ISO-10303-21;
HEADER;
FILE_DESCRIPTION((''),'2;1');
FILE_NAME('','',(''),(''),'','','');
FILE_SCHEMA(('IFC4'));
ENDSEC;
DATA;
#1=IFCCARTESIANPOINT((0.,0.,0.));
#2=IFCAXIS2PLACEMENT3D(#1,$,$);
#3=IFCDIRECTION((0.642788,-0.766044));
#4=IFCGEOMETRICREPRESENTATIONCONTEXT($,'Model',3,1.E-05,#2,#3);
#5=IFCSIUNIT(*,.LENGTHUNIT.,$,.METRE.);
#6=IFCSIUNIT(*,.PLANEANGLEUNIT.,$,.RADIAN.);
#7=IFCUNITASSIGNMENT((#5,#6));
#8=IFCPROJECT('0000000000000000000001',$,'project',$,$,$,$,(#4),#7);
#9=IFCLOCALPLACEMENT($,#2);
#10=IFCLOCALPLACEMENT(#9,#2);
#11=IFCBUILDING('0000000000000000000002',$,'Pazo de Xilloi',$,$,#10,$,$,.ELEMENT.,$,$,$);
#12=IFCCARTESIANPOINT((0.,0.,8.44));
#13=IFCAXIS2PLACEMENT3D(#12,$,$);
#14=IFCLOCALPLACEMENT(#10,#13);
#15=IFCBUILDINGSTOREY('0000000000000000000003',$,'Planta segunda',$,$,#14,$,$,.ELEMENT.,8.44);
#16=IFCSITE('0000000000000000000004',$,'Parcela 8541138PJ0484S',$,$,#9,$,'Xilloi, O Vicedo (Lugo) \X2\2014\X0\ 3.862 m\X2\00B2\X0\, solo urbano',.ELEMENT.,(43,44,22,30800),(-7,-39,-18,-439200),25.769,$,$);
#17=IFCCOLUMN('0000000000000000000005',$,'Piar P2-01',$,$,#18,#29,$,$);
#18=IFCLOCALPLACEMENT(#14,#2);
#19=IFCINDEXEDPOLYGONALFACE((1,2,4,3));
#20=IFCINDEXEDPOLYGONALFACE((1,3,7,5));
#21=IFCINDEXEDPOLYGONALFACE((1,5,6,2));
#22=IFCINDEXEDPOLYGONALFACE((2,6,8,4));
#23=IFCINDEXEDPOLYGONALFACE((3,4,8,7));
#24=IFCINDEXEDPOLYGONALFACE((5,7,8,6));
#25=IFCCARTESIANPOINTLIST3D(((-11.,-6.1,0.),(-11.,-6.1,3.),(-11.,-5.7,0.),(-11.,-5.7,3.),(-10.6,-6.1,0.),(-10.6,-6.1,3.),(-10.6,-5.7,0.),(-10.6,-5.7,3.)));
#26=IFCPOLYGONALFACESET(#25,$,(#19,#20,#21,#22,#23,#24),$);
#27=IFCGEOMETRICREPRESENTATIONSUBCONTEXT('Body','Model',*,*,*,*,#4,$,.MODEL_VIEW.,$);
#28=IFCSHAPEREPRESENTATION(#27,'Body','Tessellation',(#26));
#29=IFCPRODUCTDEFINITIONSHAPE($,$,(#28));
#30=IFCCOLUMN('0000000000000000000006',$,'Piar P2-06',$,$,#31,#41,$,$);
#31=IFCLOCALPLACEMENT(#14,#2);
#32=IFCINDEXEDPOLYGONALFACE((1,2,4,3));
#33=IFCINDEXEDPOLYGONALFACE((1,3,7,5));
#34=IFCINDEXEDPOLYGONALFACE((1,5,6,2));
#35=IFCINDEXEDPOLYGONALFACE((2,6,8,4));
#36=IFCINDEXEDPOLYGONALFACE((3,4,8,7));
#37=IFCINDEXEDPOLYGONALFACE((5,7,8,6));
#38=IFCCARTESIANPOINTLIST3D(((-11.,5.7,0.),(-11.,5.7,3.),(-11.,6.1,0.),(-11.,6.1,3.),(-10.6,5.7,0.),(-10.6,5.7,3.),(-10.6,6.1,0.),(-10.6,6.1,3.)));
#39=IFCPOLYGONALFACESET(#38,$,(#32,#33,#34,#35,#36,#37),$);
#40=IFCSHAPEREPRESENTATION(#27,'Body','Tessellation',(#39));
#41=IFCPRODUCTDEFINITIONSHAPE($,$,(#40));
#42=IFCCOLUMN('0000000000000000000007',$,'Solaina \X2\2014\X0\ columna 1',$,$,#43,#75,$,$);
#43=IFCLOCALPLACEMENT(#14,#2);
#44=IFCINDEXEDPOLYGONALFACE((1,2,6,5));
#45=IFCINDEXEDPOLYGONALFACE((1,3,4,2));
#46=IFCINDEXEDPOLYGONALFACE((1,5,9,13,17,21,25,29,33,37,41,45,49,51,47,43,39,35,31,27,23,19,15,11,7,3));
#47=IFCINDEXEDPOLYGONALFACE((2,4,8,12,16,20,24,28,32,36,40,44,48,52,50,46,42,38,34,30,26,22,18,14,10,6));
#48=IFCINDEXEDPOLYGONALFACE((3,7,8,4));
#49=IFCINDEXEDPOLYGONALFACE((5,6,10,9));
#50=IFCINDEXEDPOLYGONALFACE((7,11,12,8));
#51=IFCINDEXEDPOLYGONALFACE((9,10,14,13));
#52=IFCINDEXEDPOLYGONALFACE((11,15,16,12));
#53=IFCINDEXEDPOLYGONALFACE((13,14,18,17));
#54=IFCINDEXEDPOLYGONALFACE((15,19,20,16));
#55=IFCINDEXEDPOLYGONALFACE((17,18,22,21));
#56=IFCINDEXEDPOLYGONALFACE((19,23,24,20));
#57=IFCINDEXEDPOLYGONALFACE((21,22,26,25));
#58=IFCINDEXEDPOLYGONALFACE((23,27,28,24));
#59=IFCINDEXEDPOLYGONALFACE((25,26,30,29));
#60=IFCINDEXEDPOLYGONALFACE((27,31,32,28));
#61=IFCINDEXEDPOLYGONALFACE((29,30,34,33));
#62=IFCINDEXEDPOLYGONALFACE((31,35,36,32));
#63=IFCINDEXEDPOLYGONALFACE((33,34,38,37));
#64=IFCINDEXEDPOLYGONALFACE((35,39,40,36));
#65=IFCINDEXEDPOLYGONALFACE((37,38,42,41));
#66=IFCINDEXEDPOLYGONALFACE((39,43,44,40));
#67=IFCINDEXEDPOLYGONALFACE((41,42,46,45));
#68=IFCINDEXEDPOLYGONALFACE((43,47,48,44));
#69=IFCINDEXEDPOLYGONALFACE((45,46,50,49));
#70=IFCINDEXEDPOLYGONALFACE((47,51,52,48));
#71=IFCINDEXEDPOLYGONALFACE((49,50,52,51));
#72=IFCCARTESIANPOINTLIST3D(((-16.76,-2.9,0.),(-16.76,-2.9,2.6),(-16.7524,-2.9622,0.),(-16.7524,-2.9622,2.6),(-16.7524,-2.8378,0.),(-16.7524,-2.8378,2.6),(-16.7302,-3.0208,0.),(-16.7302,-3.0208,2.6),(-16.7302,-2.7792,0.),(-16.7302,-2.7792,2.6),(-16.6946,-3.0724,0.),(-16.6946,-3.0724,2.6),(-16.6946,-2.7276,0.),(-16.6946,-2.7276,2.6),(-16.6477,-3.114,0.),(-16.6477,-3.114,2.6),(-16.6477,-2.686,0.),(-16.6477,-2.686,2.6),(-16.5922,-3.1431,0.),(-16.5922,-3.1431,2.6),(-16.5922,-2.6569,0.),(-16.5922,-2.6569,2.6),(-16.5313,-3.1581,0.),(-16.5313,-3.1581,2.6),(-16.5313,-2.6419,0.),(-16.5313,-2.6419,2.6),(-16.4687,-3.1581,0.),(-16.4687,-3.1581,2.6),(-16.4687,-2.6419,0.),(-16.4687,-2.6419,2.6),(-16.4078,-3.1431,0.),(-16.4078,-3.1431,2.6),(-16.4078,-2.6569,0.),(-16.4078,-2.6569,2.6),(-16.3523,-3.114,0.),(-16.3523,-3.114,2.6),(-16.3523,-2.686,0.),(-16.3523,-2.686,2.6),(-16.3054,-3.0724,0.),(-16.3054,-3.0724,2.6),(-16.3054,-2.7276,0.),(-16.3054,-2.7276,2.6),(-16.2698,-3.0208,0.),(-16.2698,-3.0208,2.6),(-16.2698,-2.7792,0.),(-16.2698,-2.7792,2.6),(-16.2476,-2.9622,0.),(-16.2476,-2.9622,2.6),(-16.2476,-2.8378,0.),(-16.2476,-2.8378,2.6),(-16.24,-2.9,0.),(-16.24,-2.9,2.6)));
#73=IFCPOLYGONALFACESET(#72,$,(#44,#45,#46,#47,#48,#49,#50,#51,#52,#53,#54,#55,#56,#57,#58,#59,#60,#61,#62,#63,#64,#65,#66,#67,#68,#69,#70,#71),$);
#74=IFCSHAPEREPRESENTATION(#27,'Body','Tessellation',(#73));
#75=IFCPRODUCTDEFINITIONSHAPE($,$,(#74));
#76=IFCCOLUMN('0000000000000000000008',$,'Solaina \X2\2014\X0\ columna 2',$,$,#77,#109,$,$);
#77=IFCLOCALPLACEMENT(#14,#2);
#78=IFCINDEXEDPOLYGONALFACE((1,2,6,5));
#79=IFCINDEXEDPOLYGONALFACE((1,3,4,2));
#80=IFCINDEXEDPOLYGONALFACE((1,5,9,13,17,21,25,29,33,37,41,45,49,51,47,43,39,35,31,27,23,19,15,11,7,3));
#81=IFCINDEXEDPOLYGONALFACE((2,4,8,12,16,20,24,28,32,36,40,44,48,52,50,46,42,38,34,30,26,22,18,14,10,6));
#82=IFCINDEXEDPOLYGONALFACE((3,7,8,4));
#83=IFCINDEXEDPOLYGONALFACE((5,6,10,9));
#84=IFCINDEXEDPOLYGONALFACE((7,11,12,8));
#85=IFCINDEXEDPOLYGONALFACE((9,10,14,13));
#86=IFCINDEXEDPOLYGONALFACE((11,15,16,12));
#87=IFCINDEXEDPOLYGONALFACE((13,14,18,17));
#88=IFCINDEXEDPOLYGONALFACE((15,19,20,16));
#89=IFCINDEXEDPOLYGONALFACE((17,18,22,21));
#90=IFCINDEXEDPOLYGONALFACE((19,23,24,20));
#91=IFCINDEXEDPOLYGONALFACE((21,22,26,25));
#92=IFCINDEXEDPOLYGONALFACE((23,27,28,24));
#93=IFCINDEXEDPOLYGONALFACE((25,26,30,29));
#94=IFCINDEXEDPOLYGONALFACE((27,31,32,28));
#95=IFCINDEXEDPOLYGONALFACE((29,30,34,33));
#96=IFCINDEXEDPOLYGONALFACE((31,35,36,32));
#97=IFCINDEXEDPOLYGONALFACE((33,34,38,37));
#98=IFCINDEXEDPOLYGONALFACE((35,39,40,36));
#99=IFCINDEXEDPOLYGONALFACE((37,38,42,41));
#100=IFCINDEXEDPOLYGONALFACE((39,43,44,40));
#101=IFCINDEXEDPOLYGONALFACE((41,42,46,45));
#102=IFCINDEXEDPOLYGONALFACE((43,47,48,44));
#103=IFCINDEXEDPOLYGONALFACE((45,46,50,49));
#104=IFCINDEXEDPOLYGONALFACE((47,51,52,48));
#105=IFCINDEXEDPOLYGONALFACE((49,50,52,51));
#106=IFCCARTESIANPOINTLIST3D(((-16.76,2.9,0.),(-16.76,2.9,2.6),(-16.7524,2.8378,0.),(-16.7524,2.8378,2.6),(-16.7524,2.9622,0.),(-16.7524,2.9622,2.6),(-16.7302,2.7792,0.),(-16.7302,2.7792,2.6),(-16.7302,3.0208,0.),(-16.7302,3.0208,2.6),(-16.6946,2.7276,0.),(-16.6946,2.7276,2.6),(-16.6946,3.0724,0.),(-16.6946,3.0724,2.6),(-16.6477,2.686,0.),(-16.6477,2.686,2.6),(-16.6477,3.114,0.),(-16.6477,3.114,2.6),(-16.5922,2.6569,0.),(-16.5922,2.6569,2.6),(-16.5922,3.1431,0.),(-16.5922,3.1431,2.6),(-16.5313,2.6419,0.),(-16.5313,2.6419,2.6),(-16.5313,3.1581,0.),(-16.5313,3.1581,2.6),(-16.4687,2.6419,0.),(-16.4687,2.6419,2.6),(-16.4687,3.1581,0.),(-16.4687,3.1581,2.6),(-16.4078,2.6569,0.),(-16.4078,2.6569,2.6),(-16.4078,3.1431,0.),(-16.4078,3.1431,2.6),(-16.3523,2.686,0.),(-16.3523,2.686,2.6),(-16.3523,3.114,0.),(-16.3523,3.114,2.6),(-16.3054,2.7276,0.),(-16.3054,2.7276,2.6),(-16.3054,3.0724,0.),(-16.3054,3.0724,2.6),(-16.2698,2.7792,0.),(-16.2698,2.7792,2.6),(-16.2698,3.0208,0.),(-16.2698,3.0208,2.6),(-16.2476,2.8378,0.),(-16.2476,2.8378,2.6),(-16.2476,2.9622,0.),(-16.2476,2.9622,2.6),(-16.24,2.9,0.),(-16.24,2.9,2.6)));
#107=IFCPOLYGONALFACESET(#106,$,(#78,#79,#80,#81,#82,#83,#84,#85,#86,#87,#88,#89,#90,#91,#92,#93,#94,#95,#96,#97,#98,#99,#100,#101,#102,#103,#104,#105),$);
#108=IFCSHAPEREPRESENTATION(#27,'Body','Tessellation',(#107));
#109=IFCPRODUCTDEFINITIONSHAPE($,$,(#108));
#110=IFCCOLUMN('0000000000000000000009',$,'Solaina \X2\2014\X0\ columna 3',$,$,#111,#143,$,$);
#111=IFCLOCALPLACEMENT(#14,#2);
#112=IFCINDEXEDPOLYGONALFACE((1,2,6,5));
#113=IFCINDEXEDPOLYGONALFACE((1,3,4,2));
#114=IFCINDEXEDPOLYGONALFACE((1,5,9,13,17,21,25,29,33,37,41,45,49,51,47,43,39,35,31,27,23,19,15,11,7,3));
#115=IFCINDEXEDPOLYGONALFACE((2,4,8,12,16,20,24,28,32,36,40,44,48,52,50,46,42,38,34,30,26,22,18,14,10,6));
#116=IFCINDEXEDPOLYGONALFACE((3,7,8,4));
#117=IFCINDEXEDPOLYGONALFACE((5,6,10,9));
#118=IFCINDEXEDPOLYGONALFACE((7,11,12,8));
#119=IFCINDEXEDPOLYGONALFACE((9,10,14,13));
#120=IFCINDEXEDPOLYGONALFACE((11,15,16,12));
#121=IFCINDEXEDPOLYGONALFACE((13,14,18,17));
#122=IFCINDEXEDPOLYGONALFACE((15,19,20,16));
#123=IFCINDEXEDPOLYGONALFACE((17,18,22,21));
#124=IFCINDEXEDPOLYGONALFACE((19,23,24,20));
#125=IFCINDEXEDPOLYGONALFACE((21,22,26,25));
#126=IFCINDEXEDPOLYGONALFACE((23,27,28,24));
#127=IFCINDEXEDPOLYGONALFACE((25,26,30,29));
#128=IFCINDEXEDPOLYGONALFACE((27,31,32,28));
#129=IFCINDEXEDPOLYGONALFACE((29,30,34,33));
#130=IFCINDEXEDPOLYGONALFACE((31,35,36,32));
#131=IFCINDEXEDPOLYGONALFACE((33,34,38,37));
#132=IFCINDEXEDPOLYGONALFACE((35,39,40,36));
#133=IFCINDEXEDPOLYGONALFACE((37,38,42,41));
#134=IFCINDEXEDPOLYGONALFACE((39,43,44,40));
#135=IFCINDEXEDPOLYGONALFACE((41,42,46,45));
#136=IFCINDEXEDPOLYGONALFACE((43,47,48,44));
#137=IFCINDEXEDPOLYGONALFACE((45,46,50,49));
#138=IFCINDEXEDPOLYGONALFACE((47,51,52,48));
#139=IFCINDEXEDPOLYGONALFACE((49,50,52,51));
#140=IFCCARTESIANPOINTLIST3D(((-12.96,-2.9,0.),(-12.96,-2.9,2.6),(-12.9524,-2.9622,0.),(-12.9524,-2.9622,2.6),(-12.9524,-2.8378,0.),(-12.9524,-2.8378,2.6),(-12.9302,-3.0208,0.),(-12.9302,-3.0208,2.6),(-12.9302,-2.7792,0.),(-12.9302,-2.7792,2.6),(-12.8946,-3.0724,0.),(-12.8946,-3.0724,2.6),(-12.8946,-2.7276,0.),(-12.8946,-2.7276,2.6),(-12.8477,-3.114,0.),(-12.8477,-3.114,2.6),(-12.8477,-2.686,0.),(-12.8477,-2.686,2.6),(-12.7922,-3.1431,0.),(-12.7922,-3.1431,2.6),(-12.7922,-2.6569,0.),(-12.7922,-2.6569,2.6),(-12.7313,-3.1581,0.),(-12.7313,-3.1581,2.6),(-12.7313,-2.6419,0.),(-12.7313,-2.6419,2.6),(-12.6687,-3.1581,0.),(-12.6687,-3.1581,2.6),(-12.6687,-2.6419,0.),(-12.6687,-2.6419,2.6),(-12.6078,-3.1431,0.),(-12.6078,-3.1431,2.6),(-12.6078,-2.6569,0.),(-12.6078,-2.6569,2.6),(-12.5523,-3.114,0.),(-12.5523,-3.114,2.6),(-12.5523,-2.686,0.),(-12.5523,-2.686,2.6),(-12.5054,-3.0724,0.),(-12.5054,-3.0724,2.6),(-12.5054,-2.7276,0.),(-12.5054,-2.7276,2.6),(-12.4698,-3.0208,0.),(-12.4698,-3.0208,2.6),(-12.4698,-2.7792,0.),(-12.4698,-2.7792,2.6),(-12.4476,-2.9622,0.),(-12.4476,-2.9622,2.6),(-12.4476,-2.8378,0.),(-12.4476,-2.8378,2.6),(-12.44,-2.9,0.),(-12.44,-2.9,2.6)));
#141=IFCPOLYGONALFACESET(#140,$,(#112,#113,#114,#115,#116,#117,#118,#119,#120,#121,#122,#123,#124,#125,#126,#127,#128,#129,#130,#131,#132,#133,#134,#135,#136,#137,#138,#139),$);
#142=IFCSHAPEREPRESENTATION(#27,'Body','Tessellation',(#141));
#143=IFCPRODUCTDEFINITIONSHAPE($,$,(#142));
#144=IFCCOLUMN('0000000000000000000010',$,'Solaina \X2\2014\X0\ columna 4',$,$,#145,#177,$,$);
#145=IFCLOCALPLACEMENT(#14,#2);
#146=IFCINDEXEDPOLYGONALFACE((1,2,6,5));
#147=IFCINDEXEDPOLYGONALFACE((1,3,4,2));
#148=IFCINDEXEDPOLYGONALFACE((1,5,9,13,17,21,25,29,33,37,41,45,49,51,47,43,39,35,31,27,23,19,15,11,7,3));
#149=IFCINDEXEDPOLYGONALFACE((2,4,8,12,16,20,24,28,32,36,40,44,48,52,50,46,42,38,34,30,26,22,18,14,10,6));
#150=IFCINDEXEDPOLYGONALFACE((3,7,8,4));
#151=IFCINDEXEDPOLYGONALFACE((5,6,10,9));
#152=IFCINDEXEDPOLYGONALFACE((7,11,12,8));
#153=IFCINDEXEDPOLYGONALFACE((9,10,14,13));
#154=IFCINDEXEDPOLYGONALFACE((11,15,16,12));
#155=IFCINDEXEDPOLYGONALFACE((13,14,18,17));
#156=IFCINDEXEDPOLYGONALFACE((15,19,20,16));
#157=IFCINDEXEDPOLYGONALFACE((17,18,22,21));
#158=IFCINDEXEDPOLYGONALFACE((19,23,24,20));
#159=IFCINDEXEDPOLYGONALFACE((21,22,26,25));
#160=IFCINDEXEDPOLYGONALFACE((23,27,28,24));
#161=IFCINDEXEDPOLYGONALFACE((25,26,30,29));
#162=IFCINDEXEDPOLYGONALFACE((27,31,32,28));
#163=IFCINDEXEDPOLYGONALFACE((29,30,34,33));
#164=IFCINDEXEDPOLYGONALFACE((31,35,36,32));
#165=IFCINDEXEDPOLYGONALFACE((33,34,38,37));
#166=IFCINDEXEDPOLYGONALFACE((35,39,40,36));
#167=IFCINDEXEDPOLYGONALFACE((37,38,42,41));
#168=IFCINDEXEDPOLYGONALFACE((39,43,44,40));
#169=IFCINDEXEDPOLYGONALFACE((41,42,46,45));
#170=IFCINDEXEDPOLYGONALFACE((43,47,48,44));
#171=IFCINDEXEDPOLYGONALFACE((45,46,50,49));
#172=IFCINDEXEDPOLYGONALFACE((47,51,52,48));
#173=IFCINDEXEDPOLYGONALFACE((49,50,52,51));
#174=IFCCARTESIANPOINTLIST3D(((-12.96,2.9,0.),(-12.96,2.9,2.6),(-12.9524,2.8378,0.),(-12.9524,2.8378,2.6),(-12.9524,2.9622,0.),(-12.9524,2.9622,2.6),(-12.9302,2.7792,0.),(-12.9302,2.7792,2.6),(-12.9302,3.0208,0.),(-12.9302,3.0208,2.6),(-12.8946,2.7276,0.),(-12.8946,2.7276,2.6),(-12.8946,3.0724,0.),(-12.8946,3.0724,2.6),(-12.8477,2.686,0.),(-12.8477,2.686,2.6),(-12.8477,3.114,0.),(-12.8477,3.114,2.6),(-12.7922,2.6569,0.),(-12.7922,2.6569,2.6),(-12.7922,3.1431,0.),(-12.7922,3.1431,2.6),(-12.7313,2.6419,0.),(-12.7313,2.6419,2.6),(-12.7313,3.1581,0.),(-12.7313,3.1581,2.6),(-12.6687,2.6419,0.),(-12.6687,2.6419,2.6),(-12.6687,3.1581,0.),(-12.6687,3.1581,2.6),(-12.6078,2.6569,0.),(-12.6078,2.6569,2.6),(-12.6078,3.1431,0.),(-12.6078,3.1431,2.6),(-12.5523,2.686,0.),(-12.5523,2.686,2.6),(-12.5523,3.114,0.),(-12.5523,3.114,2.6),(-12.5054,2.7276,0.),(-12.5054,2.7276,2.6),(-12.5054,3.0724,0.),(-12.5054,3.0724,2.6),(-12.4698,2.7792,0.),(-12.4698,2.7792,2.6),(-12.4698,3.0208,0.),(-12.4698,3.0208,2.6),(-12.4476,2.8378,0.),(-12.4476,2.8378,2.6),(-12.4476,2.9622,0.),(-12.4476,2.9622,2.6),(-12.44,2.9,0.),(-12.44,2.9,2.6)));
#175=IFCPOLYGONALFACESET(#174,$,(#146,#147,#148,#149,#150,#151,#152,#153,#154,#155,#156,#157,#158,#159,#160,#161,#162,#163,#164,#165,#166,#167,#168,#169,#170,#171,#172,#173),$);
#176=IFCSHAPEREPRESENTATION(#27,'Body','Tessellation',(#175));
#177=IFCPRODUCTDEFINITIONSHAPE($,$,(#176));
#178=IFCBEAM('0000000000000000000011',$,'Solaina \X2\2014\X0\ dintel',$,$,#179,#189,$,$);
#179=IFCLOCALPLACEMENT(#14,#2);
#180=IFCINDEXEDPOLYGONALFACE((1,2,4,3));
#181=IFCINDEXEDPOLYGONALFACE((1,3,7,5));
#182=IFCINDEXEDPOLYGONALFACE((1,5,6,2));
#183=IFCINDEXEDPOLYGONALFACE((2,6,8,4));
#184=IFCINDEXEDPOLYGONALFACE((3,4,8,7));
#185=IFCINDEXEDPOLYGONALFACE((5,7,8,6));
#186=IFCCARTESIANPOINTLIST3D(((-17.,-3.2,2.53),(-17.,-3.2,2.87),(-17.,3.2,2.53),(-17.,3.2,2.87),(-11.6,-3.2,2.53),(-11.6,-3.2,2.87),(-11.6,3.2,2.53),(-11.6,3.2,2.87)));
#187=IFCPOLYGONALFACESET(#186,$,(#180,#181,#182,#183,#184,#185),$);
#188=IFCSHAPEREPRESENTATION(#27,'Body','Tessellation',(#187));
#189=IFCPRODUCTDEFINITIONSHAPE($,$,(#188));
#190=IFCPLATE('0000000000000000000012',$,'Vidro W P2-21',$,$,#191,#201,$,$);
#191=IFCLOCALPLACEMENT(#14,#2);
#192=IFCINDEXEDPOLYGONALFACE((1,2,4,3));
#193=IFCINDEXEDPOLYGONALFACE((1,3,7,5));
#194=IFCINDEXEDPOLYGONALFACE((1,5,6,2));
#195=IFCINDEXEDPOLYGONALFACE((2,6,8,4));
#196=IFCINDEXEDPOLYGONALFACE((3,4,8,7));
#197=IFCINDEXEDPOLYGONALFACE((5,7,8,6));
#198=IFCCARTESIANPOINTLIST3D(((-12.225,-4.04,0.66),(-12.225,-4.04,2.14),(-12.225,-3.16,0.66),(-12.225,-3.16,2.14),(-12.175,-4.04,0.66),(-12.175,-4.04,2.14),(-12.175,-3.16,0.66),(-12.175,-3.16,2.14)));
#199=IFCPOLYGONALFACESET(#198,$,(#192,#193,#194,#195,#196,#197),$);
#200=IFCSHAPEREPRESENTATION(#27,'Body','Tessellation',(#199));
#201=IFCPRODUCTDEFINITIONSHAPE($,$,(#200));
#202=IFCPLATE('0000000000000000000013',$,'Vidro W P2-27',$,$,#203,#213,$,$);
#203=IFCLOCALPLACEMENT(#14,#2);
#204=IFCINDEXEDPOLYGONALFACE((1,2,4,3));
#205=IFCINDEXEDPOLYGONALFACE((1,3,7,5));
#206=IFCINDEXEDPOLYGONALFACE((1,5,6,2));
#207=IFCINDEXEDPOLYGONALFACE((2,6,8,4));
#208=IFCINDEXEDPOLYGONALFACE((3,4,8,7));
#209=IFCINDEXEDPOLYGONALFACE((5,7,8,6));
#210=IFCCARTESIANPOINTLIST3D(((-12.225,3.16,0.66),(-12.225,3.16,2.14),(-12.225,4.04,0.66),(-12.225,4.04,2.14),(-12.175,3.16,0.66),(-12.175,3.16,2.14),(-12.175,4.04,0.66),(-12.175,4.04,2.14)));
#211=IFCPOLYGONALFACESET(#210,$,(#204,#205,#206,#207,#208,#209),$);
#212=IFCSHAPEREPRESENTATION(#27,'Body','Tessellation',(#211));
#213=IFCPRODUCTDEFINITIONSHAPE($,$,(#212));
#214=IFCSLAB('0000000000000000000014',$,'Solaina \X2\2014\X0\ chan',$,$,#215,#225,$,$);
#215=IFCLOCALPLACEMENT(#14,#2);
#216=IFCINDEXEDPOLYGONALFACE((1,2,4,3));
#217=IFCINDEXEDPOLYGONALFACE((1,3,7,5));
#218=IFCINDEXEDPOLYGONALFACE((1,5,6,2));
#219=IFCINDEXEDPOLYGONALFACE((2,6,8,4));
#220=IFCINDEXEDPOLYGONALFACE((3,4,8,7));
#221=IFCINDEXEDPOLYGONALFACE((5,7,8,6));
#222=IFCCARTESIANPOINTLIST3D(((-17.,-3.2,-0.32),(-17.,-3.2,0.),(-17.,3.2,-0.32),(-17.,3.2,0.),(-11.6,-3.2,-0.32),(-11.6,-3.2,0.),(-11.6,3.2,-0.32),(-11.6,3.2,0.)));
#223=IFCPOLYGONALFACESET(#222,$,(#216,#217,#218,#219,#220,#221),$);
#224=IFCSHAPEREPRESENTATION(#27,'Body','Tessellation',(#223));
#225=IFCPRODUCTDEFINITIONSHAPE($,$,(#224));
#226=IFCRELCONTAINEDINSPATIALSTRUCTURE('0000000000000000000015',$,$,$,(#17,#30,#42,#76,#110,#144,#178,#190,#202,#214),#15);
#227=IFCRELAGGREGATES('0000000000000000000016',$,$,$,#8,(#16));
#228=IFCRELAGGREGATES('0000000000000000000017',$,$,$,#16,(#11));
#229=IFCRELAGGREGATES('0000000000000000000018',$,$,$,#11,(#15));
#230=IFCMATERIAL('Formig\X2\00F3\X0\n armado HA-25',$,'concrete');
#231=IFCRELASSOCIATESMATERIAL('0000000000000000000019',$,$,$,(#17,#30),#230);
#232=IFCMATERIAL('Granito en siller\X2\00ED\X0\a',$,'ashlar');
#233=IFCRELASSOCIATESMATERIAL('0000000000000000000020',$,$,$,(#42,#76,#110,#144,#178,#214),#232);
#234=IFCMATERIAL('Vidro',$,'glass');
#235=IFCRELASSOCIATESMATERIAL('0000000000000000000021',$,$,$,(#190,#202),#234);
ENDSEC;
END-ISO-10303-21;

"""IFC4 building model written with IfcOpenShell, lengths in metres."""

from ifc_helpers import new_model, si_unit, direction, frame, origin, origin_2d, place, context, subcontext, project, spatial, rectangle, circle, extrude, material, element, save


model = new_model("IFC4")

# Units and contexts
model_context = context("Model", 3, precision=1e-05, world=origin(), true_north=direction((0.642788, -0.766044)))
body_context = subcontext(model_context, "Body", "Model", "MODEL_VIEW")
ifc_project = project(units=[si_unit("LENGTHUNIT", "METRE"), si_unit("PLANEANGLEUNIT", "RADIAN")], contexts=[model_context])

# Site, building, storey
site_placement = place(None, origin())
site = spatial("IfcSite", under=ifc_project, at=site_placement, Name="Parcela 8541138PJ0484S", LongName="Xilloi, O Vicedo (Lugo) — 3.862 m², solo urbano", CompositionType="ELEMENT", RefLatitude=(43, 44, 22, 30800), RefLongitude=(-7, -39, -18, -439200), RefElevation=25.769)
building_placement = place(site_placement, origin())
building = spatial("IfcBuilding", under=site, at=building_placement, Name="Pazo de Xilloi", CompositionType="ELEMENT")
storey_placement = place(building_placement, frame((0.0, 0.0, 8.44)))
storey = spatial("IfcBuildingStorey", under=building, at=storey_placement, Name="Planta segunda", CompositionType="ELEMENT", Elevation=8.44)

# Columns
ifc_material_1 = material(Name="Formigón armado HA-25", Category="concrete")
for number, where, name in (
    (1, (-10.8, -5.9, 1.5), "Piar P2-01"),
    (2, (-10.8, 5.9, 1.5), "Piar P2-06"),
):
    element("IfcColumn", number, at=place(storey_placement, frame(where)), inside=storey, material=ifc_material_1, Name=name, context=body_context, shape_type="SweptSolid", body=[
        extrude(rectangle(XDim=0.4, YDim=0.4, at=origin_2d()), frame((0.0, 0.0, -1.5)), (0.0, 0.0, 1.0), 3.0),
    ])
ifc_material_2 = material(Name="Granito en sillería", Category="ashlar")
for number, where, name in (
    (3, (-16.5, -2.9, 1.3), "Solaina — columna 1"),
    (4, (-16.5, 2.9, 1.3), "Solaina — columna 2"),
    (5, (-12.7, -2.9, 1.3), "Solaina — columna 3"),
    (6, (-12.7, 2.9, 1.3), "Solaina — columna 4"),
):
    element("IfcColumn", number, at=place(storey_placement, frame(where)), inside=storey, material=ifc_material_2, Name=name, context=body_context, shape_type="SweptSolid", body=[
        extrude(circle(Radius=0.26, at=origin_2d()), frame((0.0, 0.0, -1.3)), (0.0, 0.0, 1.0), 2.6),
    ])

# Beam
beam_placement = place(storey_placement, frame((-14.3, 0.0, 2.7)))
element("IfcBeam", 7, at=beam_placement, inside=storey, material=ifc_material_2, Name="Solaina — dintel", context=body_context, shape_type="SweptSolid", body=[
    extrude(rectangle(XDim=5.4, YDim=6.4, at=origin_2d()), frame((0.0, 0.0, -0.17)), (0.0, 0.0, 1.0), 0.34),
])

# Plates
ifc_material_3 = material(Name="Vidro", Category="glass")
for number, where, name in (
    (8, (-12.2, -3.6, 1.4), "Vidro W P2-21"),
    (9, (-12.2, 3.6, 1.4), "Vidro W P2-27"),
):
    element("IfcPlate", number, at=place(storey_placement, frame(where)), inside=storey, material=ifc_material_3, Name=name, context=body_context, shape_type="SweptSolid", body=[
        extrude(rectangle(XDim=0.05, YDim=0.88, at=origin_2d()), frame((0.0, 0.0, -0.74)), (0.0, 0.0, 1.0), 1.48),
    ])

# Slab
slab_placement = place(storey_placement, frame((-14.3, 0.0, -0.16)))
element("IfcSlab", 10, at=slab_placement, inside=storey, material=ifc_material_2, Name="Solaina — chan", context=body_context, shape_type="SweptSolid", body=[
    extrude(rectangle(XDim=5.4, YDim=6.4, at=origin_2d()), frame((0.0, 0.0, -0.16)), (0.0, 0.0, 1.0), 0.32),
])

save(model, "model.ifc")
